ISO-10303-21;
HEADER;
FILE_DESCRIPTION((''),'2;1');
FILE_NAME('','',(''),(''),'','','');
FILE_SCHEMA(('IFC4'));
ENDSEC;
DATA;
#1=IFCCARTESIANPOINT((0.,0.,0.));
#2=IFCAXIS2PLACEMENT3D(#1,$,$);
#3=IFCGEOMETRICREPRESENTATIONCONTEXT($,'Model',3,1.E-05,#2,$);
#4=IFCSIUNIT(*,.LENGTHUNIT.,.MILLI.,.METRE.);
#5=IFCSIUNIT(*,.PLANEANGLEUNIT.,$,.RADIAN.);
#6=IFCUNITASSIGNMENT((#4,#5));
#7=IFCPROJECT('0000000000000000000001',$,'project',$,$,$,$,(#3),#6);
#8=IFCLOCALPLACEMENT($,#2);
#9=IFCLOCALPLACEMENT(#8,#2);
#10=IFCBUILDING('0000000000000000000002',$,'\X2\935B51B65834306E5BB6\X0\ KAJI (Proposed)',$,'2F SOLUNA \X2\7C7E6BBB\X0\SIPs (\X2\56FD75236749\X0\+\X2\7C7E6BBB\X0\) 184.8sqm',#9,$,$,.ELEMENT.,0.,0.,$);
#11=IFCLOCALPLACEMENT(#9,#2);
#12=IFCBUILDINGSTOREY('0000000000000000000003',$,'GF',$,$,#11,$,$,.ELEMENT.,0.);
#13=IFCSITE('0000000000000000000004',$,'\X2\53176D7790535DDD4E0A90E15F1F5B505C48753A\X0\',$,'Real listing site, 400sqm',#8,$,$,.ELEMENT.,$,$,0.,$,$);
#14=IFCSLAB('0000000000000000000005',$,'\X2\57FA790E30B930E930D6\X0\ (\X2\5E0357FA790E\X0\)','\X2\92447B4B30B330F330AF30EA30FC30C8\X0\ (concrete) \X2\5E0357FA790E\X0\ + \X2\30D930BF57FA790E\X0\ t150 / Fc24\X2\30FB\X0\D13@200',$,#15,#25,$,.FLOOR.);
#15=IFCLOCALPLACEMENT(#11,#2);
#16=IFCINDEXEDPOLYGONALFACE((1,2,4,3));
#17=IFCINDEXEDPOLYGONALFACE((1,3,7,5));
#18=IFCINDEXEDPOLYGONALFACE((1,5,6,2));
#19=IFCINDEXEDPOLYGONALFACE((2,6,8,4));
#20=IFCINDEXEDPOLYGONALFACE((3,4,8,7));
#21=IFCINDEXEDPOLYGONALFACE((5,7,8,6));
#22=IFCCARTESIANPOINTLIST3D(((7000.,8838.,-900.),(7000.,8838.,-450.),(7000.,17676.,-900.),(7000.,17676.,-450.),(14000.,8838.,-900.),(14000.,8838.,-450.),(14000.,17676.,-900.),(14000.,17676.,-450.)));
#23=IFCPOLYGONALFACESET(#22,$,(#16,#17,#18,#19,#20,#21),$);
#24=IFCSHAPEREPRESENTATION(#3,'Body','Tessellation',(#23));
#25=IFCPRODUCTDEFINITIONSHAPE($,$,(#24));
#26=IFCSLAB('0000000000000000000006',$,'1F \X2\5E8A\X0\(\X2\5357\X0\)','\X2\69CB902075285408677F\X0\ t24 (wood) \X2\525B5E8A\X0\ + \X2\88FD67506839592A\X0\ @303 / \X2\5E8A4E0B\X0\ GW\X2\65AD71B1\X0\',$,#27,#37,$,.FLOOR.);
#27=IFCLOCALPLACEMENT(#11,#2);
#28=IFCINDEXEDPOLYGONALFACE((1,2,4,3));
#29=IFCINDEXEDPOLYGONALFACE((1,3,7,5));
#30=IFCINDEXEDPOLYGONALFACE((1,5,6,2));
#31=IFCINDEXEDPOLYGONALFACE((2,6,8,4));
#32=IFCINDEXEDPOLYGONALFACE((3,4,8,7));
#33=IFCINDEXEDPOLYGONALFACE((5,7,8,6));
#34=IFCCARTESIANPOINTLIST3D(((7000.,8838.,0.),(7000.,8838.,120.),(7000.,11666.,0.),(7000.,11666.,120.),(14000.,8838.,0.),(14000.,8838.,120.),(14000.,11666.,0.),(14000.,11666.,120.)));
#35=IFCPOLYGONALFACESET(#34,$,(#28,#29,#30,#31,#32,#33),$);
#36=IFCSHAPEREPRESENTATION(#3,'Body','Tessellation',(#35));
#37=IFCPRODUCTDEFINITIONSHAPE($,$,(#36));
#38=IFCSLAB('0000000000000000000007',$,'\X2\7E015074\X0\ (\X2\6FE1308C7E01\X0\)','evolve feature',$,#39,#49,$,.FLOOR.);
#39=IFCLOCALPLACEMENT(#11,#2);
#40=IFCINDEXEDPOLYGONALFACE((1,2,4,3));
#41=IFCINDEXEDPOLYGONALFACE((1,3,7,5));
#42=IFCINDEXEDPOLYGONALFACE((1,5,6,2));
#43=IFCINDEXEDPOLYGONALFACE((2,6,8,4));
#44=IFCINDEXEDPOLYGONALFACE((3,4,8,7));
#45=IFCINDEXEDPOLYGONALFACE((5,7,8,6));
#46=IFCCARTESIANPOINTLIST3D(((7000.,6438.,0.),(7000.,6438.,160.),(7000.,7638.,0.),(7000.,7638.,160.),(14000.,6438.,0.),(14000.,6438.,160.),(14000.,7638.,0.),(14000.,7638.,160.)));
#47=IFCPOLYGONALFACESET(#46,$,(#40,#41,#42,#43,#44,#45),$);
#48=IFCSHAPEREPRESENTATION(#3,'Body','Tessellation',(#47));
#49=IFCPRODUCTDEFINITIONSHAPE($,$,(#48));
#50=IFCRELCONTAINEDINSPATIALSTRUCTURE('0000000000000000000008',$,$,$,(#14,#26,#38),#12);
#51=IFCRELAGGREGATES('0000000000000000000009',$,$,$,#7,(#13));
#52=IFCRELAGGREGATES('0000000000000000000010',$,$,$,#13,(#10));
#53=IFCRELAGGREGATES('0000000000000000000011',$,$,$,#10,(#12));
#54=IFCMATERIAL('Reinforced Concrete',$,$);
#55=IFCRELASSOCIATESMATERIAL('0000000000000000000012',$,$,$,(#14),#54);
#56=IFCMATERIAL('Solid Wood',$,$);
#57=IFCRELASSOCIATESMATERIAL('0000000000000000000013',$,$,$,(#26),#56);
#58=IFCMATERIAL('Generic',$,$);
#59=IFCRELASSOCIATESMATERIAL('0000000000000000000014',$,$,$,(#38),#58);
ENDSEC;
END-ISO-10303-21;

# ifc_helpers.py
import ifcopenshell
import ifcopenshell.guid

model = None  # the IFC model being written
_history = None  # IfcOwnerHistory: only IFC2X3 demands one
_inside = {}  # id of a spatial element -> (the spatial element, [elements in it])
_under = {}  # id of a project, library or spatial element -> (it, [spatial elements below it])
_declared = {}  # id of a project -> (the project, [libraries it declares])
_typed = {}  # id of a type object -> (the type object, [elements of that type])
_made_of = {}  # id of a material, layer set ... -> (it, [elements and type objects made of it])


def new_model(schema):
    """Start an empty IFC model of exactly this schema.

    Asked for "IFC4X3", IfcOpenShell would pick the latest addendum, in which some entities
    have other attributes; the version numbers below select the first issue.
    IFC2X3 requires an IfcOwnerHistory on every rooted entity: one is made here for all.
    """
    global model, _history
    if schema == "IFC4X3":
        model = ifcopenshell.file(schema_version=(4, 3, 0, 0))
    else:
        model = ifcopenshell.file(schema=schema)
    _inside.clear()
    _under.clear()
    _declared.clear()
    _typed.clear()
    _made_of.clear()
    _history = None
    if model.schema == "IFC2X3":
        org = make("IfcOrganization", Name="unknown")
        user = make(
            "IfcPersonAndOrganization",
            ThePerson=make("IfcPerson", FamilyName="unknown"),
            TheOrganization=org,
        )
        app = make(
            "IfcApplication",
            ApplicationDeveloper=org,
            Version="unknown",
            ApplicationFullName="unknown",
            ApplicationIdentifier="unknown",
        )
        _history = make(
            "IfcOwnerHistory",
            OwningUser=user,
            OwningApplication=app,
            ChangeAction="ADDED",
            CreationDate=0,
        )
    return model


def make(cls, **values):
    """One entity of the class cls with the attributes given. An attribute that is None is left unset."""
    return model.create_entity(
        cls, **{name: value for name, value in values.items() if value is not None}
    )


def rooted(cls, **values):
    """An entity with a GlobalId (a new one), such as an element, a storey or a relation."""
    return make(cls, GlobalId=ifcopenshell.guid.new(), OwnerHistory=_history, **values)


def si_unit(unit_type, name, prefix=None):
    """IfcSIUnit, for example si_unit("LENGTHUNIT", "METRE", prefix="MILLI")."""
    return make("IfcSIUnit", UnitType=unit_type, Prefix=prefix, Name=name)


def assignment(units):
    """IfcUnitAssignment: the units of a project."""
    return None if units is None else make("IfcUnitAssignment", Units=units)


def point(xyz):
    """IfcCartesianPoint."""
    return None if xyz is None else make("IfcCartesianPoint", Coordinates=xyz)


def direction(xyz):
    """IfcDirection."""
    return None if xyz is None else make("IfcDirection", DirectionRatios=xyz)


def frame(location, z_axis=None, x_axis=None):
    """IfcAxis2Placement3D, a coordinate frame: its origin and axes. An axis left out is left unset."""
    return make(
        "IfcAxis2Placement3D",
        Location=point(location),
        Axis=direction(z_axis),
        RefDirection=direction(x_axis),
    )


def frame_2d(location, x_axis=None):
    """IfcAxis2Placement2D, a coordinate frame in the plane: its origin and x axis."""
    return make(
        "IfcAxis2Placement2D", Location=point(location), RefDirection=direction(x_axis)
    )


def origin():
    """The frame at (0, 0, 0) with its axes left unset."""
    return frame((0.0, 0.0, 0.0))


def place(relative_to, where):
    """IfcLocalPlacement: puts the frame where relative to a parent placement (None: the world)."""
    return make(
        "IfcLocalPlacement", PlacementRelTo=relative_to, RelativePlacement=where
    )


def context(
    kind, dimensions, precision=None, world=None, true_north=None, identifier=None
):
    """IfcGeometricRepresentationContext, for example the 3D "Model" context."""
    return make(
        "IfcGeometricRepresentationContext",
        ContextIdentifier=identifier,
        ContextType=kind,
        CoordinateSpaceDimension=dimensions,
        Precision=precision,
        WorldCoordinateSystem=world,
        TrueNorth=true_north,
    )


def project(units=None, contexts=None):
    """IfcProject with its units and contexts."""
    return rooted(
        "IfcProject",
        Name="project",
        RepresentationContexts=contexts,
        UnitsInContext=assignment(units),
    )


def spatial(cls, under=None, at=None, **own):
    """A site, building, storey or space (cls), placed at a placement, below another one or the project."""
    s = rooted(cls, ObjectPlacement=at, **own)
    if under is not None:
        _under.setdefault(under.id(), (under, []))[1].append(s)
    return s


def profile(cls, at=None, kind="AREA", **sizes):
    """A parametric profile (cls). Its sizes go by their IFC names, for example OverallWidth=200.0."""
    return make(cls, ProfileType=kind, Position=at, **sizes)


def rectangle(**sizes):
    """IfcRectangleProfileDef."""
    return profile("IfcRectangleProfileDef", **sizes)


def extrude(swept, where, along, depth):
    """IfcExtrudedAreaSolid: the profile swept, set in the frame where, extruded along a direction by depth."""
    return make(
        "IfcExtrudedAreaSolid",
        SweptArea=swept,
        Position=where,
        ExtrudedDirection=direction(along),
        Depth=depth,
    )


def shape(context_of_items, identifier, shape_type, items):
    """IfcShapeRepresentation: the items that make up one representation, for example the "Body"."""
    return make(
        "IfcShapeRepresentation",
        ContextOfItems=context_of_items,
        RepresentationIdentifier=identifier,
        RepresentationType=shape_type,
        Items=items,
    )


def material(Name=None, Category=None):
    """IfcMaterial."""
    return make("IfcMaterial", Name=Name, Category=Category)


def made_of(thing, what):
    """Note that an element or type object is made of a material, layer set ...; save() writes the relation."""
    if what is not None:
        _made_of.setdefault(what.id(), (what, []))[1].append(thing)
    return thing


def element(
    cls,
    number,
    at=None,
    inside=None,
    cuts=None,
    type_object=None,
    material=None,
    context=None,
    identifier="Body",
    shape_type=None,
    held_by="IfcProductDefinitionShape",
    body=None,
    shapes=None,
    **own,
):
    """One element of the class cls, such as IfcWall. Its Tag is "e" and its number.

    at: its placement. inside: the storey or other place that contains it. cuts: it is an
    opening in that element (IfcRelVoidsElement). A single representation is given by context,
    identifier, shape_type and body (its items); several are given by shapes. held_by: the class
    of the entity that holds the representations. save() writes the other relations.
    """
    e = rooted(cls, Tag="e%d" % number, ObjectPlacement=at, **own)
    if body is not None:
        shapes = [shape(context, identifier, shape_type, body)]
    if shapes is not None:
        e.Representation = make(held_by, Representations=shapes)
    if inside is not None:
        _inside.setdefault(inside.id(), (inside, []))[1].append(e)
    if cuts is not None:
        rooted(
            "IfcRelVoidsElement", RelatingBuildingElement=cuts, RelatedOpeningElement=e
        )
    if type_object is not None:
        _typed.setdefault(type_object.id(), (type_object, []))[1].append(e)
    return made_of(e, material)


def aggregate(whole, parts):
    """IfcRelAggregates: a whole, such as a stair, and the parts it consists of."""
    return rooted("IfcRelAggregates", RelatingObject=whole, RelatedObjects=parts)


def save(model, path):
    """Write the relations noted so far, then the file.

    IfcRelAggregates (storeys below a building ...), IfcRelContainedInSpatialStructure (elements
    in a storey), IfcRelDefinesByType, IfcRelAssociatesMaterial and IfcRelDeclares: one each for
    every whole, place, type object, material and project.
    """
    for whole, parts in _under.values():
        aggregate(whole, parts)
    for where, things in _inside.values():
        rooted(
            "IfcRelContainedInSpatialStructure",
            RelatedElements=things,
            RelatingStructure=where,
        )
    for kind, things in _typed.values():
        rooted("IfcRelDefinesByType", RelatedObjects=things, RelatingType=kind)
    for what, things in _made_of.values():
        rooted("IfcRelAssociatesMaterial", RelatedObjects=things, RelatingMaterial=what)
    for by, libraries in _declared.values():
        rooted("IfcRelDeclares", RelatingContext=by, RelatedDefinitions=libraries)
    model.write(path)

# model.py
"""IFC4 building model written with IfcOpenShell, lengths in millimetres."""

from ifc_helpers import new_model, si_unit, frame, frame_2d, origin, place, context, project, spatial, rectangle, extrude, material, element, save


model = new_model("IFC4")

# Units and contexts
model_context = context("Model", 3, precision=1e-05, world=origin())
ifc_project = project(units=[si_unit("LENGTHUNIT", "METRE", prefix="MILLI"), si_unit("PLANEANGLEUNIT", "RADIAN")], contexts=[model_context])

# Site, building, storey
site_placement = place(None, origin())
site = spatial("IfcSite", under=ifc_project, at=site_placement, Name="北海道川上郡弟子屈町", ObjectType="Real listing site, 400sqm", CompositionType="ELEMENT", RefElevation=0.0)
building_placement = place(site_placement, origin())
building = spatial("IfcBuilding", under=site, at=building_placement, Name="鍛冶場の家 KAJI (Proposed)", ObjectType="2F SOLUNA 籾殻SIPs (国産杉+籾殻) 184.8sqm", CompositionType="ELEMENT", ElevationOfRefHeight=0.0, ElevationOfTerrain=0.0)
storey_placement = place(building_placement, origin())
storey = spatial("IfcBuildingStorey", under=building, at=storey_placement, Name="GF", CompositionType="ELEMENT", Elevation=0.0)

# Slabs
ifc_material_1 = material(Name="Reinforced Concrete")
slab_1_placement = place(storey_placement, frame((3500.0, 4419.0, -450.0)))
element("IfcSlab", 1, at=slab_1_placement, inside=storey, material=ifc_material_1, Name="基礎スラブ (布基礎)", Description="鉄筋コンクリート (concrete) 布基礎 + ベタ基礎 t150 / Fc24・D13@200", PredefinedType="FLOOR", context=model_context, shape_type="SweptSolid", body=[
    extrude(rectangle(XDim=7000.0, YDim=8838.0, at=frame_2d((3500.0, 4419.0))), frame((3500.0, 4419.0, -450.0)), (0.0, 0.0, 1.0), 450.0),
])
ifc_material_2 = material(Name="Solid Wood")
slab_2_placement = place(storey_placement, frame((3500.0, 4419.0, 0.0)))
element("IfcSlab", 2, at=slab_2_placement, inside=storey, material=ifc_material_2, Name="1F 床(南)", Description="構造用合板 t24 (wood) 剛床 + 製材根太 @303 / 床下 GW断熱", PredefinedType="FLOOR", context=model_context, shape_type="SweptSolid", body=[
    extrude(rectangle(XDim=7000.0, YDim=2828.0, at=frame_2d((3500.0, 1414.0))), frame((3500.0, 4419.0, 0.0)), (0.0, 0.0, 1.0), 120.0),
])
ifc_material_3 = material(Name="Generic")
slab_3_placement = place(storey_placement, frame((3500.0, 3219.0, 0.0)))
element("IfcSlab", 3, at=slab_3_placement, inside=storey, material=ifc_material_3, Name="縁側 (濡れ縁)", Description="evolve feature", PredefinedType="FLOOR", context=model_context, shape_type="SweptSolid", body=[
    extrude(rectangle(XDim=7000.0, YDim=1200.0, at=frame_2d((3500.0, 600.0))), frame((3500.0, 3219.0, 0.0)), (0.0, 0.0, 1.0), 160.0),
])

save(model, "model.ifc")
